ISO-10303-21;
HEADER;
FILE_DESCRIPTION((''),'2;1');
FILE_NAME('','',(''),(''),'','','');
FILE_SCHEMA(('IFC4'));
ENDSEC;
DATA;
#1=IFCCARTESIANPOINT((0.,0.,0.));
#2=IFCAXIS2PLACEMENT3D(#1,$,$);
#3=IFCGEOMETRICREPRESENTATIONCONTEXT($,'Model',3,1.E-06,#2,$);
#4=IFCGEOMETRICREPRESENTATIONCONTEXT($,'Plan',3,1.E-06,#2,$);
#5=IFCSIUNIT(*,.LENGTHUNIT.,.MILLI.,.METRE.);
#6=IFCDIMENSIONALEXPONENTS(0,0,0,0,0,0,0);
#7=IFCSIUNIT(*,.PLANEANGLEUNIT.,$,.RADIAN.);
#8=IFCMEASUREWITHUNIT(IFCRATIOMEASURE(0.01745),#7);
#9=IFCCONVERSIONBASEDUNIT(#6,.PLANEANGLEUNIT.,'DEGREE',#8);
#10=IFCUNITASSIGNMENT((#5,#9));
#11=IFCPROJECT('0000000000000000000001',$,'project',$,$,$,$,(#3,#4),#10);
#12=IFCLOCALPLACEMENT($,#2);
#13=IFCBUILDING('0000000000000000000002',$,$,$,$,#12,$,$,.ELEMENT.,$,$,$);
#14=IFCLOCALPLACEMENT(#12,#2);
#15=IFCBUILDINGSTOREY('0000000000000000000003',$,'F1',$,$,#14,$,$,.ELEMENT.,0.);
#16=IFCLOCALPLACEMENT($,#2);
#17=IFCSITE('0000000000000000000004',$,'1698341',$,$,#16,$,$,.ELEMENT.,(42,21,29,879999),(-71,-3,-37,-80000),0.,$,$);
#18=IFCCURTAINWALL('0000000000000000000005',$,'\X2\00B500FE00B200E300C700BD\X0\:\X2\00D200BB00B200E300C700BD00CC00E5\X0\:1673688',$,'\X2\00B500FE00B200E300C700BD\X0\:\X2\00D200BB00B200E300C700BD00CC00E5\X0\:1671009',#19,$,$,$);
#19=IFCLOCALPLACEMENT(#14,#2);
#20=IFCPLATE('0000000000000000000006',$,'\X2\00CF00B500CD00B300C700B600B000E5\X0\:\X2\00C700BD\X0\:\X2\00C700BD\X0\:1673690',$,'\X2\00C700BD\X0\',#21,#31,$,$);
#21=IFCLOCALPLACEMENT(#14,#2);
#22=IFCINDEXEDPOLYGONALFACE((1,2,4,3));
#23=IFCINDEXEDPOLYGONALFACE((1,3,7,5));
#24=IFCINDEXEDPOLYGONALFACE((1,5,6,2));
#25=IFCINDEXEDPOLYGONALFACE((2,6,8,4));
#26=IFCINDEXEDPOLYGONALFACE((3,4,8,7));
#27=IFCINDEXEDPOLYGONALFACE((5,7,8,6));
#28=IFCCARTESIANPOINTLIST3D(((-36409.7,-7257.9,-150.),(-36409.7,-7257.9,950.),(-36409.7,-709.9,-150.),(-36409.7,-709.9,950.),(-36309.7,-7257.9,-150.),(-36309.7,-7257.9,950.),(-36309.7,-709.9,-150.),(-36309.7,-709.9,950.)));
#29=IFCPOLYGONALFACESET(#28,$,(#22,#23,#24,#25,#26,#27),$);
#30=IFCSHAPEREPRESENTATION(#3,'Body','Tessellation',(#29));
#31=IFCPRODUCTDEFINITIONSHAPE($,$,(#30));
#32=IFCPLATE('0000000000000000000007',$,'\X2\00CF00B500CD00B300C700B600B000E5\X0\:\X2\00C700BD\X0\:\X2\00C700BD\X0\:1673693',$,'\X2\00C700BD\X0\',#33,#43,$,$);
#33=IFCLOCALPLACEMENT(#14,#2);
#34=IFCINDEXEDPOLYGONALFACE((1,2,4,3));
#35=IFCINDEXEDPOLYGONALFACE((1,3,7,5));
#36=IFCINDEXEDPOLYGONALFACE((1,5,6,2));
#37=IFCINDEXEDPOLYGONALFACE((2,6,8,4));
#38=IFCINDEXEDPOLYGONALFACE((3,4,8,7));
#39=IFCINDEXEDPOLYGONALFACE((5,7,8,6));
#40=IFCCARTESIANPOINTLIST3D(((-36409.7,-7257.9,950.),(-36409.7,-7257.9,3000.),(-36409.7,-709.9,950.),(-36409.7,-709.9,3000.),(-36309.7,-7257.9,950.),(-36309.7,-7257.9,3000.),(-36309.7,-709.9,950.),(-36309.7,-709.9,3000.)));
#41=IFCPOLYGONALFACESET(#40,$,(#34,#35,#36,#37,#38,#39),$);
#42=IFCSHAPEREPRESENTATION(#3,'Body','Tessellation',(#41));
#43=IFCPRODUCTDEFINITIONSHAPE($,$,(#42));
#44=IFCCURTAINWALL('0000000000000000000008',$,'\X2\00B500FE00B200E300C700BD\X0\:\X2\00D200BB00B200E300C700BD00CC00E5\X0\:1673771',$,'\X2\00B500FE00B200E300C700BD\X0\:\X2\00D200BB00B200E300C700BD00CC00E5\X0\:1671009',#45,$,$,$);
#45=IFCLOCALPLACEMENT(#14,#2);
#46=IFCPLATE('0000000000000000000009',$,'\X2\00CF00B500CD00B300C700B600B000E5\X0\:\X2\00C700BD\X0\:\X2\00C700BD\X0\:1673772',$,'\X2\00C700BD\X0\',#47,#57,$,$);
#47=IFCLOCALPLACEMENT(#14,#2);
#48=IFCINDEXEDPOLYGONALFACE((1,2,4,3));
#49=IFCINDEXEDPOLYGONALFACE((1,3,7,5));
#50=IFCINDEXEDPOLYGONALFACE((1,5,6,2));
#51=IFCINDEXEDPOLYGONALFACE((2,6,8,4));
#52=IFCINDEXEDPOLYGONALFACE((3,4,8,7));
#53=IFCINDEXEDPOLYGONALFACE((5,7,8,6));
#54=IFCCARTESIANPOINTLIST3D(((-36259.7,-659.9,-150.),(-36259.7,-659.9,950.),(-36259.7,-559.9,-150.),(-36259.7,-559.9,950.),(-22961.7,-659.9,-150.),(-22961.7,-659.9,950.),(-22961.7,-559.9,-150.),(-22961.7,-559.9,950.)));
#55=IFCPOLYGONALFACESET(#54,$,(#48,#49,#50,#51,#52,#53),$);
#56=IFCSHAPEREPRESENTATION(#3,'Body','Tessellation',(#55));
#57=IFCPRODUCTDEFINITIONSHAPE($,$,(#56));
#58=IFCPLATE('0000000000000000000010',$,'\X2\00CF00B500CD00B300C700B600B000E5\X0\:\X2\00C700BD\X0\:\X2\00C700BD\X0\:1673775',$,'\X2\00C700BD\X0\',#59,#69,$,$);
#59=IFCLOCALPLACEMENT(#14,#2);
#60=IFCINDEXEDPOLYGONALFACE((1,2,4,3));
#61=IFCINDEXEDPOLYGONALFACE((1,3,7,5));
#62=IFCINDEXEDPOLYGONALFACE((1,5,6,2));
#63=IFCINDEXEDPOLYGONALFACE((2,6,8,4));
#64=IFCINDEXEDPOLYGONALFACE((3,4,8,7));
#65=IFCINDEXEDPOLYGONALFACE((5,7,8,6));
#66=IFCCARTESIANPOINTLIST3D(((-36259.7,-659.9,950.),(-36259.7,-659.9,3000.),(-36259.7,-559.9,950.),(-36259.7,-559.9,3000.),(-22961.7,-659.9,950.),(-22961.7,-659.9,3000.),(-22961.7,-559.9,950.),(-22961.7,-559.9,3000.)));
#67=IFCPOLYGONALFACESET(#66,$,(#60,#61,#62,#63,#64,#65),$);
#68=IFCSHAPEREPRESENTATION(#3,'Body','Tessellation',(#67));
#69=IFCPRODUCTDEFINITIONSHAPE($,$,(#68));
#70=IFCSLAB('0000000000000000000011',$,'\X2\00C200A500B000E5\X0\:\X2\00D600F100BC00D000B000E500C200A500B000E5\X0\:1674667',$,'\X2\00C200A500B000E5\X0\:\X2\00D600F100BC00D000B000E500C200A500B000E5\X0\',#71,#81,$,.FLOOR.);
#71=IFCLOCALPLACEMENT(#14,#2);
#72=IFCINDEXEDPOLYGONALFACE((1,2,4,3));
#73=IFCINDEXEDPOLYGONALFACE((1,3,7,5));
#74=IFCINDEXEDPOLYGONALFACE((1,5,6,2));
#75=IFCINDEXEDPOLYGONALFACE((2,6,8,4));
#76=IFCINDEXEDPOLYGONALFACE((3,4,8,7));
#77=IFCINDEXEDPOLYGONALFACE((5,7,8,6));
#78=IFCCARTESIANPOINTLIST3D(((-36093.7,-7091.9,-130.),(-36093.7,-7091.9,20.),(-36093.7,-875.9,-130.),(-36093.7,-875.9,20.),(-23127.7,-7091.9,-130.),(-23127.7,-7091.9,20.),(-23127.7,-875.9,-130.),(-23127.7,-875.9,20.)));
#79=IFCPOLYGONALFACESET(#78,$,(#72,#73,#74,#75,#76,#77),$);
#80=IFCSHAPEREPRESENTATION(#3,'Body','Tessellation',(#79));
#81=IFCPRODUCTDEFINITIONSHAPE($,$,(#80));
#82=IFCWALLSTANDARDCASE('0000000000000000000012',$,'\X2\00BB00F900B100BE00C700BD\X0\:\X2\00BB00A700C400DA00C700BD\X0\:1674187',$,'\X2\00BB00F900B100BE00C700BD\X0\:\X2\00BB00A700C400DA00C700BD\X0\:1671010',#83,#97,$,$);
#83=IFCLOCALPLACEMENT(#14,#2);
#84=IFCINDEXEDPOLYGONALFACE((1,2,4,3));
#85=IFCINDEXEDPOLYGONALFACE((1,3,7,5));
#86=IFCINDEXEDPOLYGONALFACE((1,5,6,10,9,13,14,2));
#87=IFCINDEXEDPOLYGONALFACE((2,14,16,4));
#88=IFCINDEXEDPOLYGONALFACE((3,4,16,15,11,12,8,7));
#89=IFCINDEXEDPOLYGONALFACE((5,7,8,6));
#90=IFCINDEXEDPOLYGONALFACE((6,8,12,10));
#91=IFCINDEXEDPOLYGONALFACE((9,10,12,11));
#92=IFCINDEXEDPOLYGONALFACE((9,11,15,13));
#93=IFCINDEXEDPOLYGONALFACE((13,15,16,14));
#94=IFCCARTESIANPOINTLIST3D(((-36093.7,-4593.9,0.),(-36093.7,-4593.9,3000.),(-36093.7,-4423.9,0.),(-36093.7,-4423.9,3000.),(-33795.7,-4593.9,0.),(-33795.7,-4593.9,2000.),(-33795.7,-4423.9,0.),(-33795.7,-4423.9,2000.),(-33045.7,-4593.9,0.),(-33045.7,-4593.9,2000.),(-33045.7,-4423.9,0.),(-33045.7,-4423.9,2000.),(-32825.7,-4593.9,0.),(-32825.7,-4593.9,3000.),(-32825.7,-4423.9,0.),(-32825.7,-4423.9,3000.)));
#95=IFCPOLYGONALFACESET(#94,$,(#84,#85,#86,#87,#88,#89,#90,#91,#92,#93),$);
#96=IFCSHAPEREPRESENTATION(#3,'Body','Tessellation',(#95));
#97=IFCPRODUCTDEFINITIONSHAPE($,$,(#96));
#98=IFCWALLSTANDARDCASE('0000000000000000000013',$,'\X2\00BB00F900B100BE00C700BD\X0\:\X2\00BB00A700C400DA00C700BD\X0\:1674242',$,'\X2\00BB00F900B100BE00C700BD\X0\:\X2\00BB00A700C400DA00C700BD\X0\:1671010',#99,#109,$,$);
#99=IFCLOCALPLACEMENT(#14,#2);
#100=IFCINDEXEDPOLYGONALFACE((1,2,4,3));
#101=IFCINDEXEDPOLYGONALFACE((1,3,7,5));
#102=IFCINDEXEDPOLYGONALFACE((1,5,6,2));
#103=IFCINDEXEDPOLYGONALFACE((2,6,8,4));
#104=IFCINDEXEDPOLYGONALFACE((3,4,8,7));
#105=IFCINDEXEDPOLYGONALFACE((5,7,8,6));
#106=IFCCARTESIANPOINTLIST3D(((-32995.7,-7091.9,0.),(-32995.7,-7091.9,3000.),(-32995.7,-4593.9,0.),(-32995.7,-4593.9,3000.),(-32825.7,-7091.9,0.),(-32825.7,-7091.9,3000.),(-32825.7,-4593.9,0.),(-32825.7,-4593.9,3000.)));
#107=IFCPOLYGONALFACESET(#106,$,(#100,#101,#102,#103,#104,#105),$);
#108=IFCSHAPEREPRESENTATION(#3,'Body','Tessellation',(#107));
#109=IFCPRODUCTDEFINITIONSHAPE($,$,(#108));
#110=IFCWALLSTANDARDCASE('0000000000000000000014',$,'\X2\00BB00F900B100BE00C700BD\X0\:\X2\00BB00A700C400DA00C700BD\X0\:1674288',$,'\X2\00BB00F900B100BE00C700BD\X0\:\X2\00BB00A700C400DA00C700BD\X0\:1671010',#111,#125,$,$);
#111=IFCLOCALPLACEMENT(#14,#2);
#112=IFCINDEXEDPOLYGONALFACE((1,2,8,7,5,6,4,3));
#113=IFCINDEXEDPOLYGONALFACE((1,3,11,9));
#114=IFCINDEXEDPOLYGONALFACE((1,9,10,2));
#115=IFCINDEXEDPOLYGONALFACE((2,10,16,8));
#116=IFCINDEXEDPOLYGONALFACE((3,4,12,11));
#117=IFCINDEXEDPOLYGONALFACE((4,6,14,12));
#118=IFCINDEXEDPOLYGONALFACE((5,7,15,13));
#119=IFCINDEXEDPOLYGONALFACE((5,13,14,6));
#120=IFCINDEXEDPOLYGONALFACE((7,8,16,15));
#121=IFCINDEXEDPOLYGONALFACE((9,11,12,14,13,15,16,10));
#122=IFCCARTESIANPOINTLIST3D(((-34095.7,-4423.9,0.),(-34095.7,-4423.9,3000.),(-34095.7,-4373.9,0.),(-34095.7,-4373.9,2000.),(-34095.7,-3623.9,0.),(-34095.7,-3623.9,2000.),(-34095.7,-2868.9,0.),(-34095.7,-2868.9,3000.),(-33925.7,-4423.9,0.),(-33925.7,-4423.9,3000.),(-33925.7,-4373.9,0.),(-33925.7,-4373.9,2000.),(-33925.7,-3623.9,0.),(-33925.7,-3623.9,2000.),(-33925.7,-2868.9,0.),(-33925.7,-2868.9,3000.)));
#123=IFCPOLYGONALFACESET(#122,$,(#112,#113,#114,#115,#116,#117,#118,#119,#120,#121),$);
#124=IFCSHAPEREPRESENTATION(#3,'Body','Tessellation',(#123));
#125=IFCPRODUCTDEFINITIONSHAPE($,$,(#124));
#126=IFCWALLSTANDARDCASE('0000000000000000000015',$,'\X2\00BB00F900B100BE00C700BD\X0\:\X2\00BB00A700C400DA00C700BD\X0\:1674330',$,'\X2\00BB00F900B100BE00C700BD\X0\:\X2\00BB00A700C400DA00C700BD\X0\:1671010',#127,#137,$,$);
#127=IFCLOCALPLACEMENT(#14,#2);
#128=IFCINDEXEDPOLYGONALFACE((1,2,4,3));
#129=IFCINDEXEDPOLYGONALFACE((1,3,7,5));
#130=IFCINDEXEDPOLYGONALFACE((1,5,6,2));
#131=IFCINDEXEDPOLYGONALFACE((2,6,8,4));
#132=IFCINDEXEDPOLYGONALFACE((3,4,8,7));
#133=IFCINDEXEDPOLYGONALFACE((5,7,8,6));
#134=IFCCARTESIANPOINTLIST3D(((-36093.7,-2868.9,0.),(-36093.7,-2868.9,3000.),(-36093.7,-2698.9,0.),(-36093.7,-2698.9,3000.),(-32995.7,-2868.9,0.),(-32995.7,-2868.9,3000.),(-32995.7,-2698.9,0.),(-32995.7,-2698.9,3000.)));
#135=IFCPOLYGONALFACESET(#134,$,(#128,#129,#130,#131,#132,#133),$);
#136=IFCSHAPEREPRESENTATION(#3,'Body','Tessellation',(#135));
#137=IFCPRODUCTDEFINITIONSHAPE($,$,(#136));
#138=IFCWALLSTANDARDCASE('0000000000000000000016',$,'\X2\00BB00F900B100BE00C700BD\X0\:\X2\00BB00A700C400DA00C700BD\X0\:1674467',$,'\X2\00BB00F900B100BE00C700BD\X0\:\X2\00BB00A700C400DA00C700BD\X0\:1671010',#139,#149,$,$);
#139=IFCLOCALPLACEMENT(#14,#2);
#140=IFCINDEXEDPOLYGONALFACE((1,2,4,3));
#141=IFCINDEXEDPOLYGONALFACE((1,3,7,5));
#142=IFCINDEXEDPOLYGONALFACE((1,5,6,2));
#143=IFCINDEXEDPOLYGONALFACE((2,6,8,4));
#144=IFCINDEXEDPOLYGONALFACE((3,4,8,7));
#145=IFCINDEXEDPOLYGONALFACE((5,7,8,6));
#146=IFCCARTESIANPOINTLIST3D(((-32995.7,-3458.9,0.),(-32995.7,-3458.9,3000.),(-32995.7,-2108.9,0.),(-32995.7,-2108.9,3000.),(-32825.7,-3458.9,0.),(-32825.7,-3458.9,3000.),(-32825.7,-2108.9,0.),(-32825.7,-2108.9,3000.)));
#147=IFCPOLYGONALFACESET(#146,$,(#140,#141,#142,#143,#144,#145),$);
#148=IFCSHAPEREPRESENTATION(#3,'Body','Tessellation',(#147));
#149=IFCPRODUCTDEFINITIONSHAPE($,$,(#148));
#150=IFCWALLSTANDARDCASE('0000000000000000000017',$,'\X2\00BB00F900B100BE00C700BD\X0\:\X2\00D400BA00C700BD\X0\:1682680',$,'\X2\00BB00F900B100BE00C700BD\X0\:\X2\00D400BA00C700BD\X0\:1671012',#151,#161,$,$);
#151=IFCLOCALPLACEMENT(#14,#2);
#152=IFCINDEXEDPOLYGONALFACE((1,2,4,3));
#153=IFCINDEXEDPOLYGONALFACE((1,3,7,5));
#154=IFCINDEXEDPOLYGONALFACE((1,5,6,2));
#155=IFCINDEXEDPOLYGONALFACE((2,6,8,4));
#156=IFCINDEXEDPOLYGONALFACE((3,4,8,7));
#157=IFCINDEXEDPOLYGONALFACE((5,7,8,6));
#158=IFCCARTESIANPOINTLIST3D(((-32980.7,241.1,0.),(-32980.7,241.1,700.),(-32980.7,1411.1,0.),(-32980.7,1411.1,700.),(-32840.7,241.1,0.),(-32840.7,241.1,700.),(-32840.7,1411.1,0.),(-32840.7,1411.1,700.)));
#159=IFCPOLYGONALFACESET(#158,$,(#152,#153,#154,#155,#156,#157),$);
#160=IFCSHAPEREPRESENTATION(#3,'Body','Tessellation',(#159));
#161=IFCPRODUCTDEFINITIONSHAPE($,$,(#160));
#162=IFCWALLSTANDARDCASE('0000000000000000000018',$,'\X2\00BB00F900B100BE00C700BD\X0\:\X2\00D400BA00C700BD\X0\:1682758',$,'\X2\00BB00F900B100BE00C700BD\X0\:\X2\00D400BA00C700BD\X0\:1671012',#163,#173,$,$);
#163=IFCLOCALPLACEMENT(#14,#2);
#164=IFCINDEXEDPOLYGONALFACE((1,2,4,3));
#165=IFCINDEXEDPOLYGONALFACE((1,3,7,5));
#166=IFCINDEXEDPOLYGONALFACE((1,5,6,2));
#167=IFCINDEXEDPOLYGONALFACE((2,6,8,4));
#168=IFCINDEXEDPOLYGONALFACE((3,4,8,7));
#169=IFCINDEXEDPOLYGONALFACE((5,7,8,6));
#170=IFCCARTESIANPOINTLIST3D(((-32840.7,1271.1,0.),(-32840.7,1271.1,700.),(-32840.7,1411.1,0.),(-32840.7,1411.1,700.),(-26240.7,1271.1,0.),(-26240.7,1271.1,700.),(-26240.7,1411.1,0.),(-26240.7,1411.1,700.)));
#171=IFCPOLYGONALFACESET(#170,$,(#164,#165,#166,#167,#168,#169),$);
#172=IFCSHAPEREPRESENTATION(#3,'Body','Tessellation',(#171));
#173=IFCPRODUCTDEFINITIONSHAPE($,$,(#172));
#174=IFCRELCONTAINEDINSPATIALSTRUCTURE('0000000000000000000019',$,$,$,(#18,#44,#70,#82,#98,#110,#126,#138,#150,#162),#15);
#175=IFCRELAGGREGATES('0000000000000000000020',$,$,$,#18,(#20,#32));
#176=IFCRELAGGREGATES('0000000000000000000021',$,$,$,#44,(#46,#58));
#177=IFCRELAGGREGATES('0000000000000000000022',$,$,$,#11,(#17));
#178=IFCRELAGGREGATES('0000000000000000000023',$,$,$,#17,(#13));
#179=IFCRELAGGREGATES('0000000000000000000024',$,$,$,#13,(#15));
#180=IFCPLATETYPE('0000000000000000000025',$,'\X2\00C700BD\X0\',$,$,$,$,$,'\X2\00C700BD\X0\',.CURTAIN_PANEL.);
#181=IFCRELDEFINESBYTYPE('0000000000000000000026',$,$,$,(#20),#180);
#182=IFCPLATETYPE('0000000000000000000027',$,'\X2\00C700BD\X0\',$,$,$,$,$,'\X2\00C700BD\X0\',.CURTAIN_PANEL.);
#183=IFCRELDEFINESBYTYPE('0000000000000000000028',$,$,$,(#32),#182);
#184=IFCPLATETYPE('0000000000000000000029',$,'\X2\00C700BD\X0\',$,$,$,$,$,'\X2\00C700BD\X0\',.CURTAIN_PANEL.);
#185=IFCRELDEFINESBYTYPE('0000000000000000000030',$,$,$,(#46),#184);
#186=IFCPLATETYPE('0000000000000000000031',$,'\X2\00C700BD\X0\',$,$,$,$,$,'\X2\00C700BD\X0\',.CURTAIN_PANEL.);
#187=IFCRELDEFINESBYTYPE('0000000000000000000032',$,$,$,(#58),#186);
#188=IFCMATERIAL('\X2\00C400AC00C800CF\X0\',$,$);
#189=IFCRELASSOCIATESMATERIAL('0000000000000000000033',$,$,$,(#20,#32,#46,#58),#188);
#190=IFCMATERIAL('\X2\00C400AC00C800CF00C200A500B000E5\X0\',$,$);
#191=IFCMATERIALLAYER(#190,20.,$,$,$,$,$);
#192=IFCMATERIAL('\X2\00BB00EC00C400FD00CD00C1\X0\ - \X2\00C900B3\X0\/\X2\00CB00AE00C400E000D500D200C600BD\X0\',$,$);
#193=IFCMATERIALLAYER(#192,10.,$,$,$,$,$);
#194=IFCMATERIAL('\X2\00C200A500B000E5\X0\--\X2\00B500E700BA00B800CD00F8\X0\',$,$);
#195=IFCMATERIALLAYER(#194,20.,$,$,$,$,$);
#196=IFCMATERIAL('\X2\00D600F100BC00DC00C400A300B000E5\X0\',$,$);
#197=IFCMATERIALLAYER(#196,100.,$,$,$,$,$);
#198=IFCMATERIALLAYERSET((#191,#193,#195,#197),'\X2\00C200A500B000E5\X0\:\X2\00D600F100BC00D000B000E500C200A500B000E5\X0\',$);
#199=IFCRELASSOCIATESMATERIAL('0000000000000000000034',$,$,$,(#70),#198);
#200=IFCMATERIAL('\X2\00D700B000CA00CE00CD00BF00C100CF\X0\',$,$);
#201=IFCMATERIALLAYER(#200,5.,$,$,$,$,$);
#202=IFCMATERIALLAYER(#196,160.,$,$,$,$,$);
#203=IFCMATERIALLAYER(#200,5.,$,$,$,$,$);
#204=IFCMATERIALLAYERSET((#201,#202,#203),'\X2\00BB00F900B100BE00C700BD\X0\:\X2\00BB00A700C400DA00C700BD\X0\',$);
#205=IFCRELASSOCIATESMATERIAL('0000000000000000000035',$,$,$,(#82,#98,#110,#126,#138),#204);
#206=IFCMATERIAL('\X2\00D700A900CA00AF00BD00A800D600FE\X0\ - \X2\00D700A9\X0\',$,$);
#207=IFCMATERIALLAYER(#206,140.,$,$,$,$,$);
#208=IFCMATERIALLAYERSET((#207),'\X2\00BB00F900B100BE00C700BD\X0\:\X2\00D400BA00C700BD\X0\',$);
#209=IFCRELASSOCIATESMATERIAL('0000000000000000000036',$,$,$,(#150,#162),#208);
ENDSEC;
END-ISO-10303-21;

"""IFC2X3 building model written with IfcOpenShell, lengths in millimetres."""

from ifc_helpers import new_model, entity, si_unit, converted_unit, frame, frame_2d, origin, origin_2d_with_axis, place, context, project, spatial, rectangle, extrude, source, transform, mapped, material, layer, layer_set, layer_usage, type_object, type_shapes, element, aggregate, save


model = new_model("IFC2X3")

# Units and contexts
model_context = context("Model", 3, precision=1e-06, world=origin())
plan_context = context("Plan", 3, precision=1e-06, world=origin())
ifc_project = project(units=[si_unit("LENGTHUNIT", "METRE", prefix="MILLI"), converted_unit("PLANEANGLEUNIT", "DEGREE", entity("IfcRatioMeasure", 0.01745), si_unit("PLANEANGLEUNIT", "RADIAN"), dimensions=[0, 0, 0, 0, 0, 0, 0])], contexts=[model_context, plan_context])

# Site, building, storey
site_placement = place(None, origin())
site = spatial("IfcSite", under=ifc_project, at=site_placement, Name="1698341", CompositionType="ELEMENT", RefLatitude=(42, 21, 29, 879999), RefLongitude=(-71, -3, -37, -80000), RefElevation=0.0)
building_placement = place(None, origin())
building = spatial("IfcBuilding", under=site, at=building_placement, CompositionType="ELEMENT")
storey_placement = place(building_placement, origin())
storey = spatial("IfcBuildingStorey", under=building, at=storey_placement, Name="F1", CompositionType="ELEMENT", Elevation=0.0)

# Curtain walls, plates
curtain_wall_1_placement = place(storey_placement, origin())
curtain_wall_1 = element("IfcCurtainWall", 1, at=curtain_wall_1_placement, inside=storey, Name="µþ²ãÇ½:Ò»²ãÇ½Ìå:1673688", ObjectType="µþ²ãÇ½:Ò»²ãÇ½Ìå:1671009")
ifc_material_1 = material(Name="Ä¬ÈÏ")
plate_type_1 = type_object("IfcPlateType", Name="Ç½", ElementType="Ç½", PredefinedType="CURTAIN_PANEL")
shared_shape_1 = source(origin(), model_context, "Body", "SweptSolid", [
    extrude(rectangle(XDim=100.0, YDim=6548.0, at=origin_2d_with_axis()), frame((0.0, 100.0, 0.0), z_axis=(0.0, 0.0, 1.0), x_axis=(0.0, 1.0, 0.0)), (0.0, 0.0, 1.0), 1100.0),
])
type_shapes(plate_type_1, [shared_shape_1])
plate_1_placement = place(None, frame((-36259.7, -3983.9, -150.0), z_axis=(0.0, 0.0, 1.0), x_axis=(0.0, 1.0, 0.0)))
plate_1 = element("IfcPlate", 2, at=plate_1_placement, type_object=plate_type_1, material=ifc_material_1, Name="ÏµÍ³Ç¶°å:Ç½:Ç½:1673690", ObjectType="Ç½", context=model_context, shape_type="MappedRepresentation", body=[
    mapped(shared_shape_1, transform((0.0, 0.0, 0.0), scale=1.0)),
])
plate_type_2 = type_object("IfcPlateType", Name="Ç½", ElementType="Ç½", PredefinedType="CURTAIN_PANEL")
shared_shape_2 = source(origin(), model_context, "Body", "SweptSolid", [
    extrude(rectangle(XDim=100.0, YDim=6548.0, at=origin_2d_with_axis()), frame((0.0, 100.0, 0.0), z_axis=(0.0, 0.0, 1.0), x_axis=(0.0, 1.0, 0.0)), (0.0, 0.0, 1.0), 2050.0),
])
type_shapes(plate_type_2, [shared_shape_2])
plate_2_placement = place(None, frame((-36259.7, -3983.9, 950.0), z_axis=(0.0, 0.0, 1.0), x_axis=(0.0, 1.0, 0.0)))
plate_2 = element("IfcPlate", 3, at=plate_2_placement, type_object=plate_type_2, material=ifc_material_1, Name="ÏµÍ³Ç¶°å:Ç½:Ç½:1673693", ObjectType="Ç½", context=model_context, shape_type="MappedRepresentation", body=[
    mapped(shared_shape_2, transform((0.0, 0.0, 0.0), scale=1.0)),
])
aggregate(curtain_wall_1, [plate_1, plate_2])
curtain_wall_2_placement = place(storey_placement, origin())
curtain_wall_2 = element("IfcCurtainWall", 4, at=curtain_wall_2_placement, inside=storey, Name="µþ²ãÇ½:Ò»²ãÇ½Ìå:1673771", ObjectType="µþ²ãÇ½:Ò»²ãÇ½Ìå:1671009")
plate_type_3 = type_object("IfcPlateType", Name="Ç½", ElementType="Ç½", PredefinedType="CURTAIN_PANEL")
shared_shape_3 = source(origin(), model_context, "Body", "SweptSolid", [
    extrude(rectangle(XDim=100.0, YDim=13298.0, at=origin_2d_with_axis()), frame((0.0, 100.0, 0.0), z_axis=(0.0, 0.0, 1.0), x_axis=(0.0, 1.0, 0.0)), (0.0, 0.0, 1.0), 1100.0),
])
type_shapes(plate_type_3, [shared_shape_3])
plate_3_placement = place(None, frame((-29610.7, -709.9, -150.0)))
plate_3 = element("IfcPlate", 5, at=plate_3_placement, type_object=plate_type_3, material=ifc_material_1, Name="ÏµÍ³Ç¶°å:Ç½:Ç½:1673772", ObjectType="Ç½", context=model_context, shape_type="MappedRepresentation", body=[
    mapped(shared_shape_3, transform((0.0, 0.0, 0.0), scale=1.0)),
])
plate_type_4 = type_object("IfcPlateType", Name="Ç½", ElementType="Ç½", PredefinedType="CURTAIN_PANEL")
shared_shape_4 = source(origin(), model_context, "Body", "SweptSolid", [
    extrude(rectangle(XDim=100.0, YDim=13298.0, at=origin_2d_with_axis()), frame((0.0, 100.0, 0.0), z_axis=(0.0, 0.0, 1.0), x_axis=(0.0, 1.0, 0.0)), (0.0, 0.0, 1.0), 2050.0),
])
type_shapes(plate_type_4, [shared_shape_4])
plate_4_placement = place(None, frame((-29610.7, -709.9, 950.0)))
plate_4 = element("IfcPlate", 6, at=plate_4_placement, type_object=plate_type_4, material=ifc_material_1, Name="ÏµÍ³Ç¶°å:Ç½:Ç½:1673775", ObjectType="Ç½", context=model_context, shape_type="MappedRepresentation", body=[
    mapped(shared_shape_4, transform((0.0, 0.0, 0.0), scale=1.0)),
])
aggregate(curtain_wall_2, [plate_3, plate_4])

# Slab
ifc_material_2 = material(Name="Ä¬ÈÏÂ¥°å")
ifc_layer_1 = layer(ifc_material_2, 20.0)
ifc_material_3 = material(Name="»ìÄýÍÁ - É³/Ë®ÄàÕÒÆ½")
ifc_layer_2 = layer(ifc_material_3, 10.0)
ifc_material_4 = material(Name="Â¥°å--µçº¸Íø")
ifc_layer_3 = layer(ifc_material_4, 20.0)
ifc_material_5 = material(Name="Öñ¼ÜÄ£°å")
ifc_layer_4 = layer(ifc_material_5, 100.0)
ifc_layer_set_1 = layer_set([ifc_layer_1, ifc_layer_2, ifc_layer_3, ifc_layer_4], Name="Â¥°å:Öñ¼Ð°åÂ¥°å")
ifc_layer_usage_1 = layer_usage(ifc_layer_set_1, "AXIS3", "POSITIVE", 0.0)
slab_placement = place(storey_placement, frame((-36093.7, -7091.9, -130.0)))
element("IfcSlab", 7, at=slab_placement, inside=storey, material=ifc_layer_usage_1, Name="Â¥°å:Öñ¼Ð°åÂ¥°å:1674667", ObjectType="Â¥°å:Öñ¼Ð°åÂ¥°å", PredefinedType="FLOOR", context=model_context, shape_type="SweptSolid", body=[
    extrude(rectangle(XDim=6216.0, YDim=12966.0, at=frame_2d((0.0, 0.0), x_axis=(0.0, -1.0))), frame((6483.0, 3108.0, 150.0), z_axis=(0.0, 0.0, -1.0), x_axis=(-1.0, 0.0, 0.0)), (0.0, 0.0, 1.0), 150.0),
])

# Shared definitions
ifc_material_6 = material(Name="×°ÊÎÍ¿ÁÏ")

# Wall, opening
ifc_layer_5 = layer(ifc_material_6, 5.0)
ifc_layer_6 = layer(ifc_material_5, 160.0)
ifc_layer_7 = layer(ifc_material_6, 5.0)
ifc_layer_set_2 = layer_set([ifc_layer_5, ifc_layer_6, ifc_layer_7], Name="»ù±¾Ç½:»§ÄÚÇ½")
ifc_layer_usage_2 = layer_usage(ifc_layer_set_2, "AXIS2", "NEGATIVE", 85.0)
wall_1_placement = place(storey_placement, frame((-36093.7, -4508.9, 0.0)))
wall_1 = element("IfcWallStandardCase", 8, at=wall_1_placement, inside=storey, material=ifc_layer_usage_2, Name="»ù±¾Ç½:»§ÄÚÇ½:1674187", ObjectType="»ù±¾Ç½:»§ÄÚÇ½:1671010", context=model_context, shape_type="SweptSolid", body=[
    extrude(rectangle(XDim=3268.0, YDim=170.0, at=frame_2d((1634.0, 0.0), x_axis=(-1.0, 0.0))), origin(), (0.0, 0.0, 1.0), 3000.0),
])
opening_1_placement = place(wall_1_placement, frame((3048.0, 85.0, 0.0)))
element("IfcOpeningElement", 9, at=opening_1_placement, cuts=wall_1, ObjectType="Opening", context=model_context, shape_type="SweptSolid", body=[
    extrude(rectangle(XDim=750.0, YDim=2000.0, at=frame_2d((1000.0, 375.0), x_axis=(0.0, -1.0))), frame((0.0, 0.0, 0.0), z_axis=(0.0, -1.0, 0.0), x_axis=(0.0, 0.0, 1.0)), (0.0, 0.0, 1.0), 170.0),
])

# Wall
ifc_layer_usage_3 = layer_usage(ifc_layer_set_2, "AXIS2", "NEGATIVE", 85.0)
wall_2_placement = place(storey_placement, frame((-32910.7, -4593.9, 0.0), z_axis=(0.0, 0.0, 1.0), x_axis=(0.0, -1.0, 0.0)))
element("IfcWallStandardCase", 10, at=wall_2_placement, inside=storey, material=ifc_layer_usage_3, Name="»ù±¾Ç½:»§ÄÚÇ½:1674242", ObjectType="»ù±¾Ç½:»§ÄÚÇ½:1671010", context=model_context, shape_type="SweptSolid", body=[
    extrude(rectangle(XDim=2498.0, YDim=170.0, at=frame_2d((1249.0, 0.0), x_axis=(-1.0, 0.0))), origin(), (0.0, 0.0, 1.0), 3000.0),
])

# Wall, opening
ifc_layer_usage_4 = layer_usage(ifc_layer_set_2, "AXIS2", "NEGATIVE", 85.0)
wall_3_placement = place(storey_placement, frame((-34010.7, -4423.9, 0.0), z_axis=(0.0, 0.0, 1.0), x_axis=(0.0, 1.0, 0.0)))
wall_3 = element("IfcWallStandardCase", 11, at=wall_3_placement, inside=storey, material=ifc_layer_usage_4, Name="»ù±¾Ç½:»§ÄÚÇ½:1674288", ObjectType="»ù±¾Ç½:»§ÄÚÇ½:1671010", context=model_context, shape_type="SweptSolid", body=[
    extrude(rectangle(XDim=1555.0, YDim=170.0, at=frame_2d((777.5, 0.0), x_axis=(-1.0, 0.0))), origin(), (0.0, 0.0, 1.0), 3000.0),
])
opening_2_placement = place(wall_3_placement, frame((50.0, -85.0, 0.0)))
element("IfcOpeningElement", 12, at=opening_2_placement, cuts=wall_3, ObjectType="Opening", context=model_context, shape_type="SweptSolid", body=[
    extrude(rectangle(XDim=750.0, YDim=2000.0, at=frame_2d((1000.0, 375.0), x_axis=(0.0, -1.0))), frame((0.0, 0.0, 0.0), z_axis=(0.0, 1.0, 0.0), x_axis=(0.0, 0.0, 1.0)), (0.0, 0.0, 1.0), 170.0),
])

# Walls
ifc_layer_usage_5 = layer_usage(ifc_layer_set_2, "AXIS2", "NEGATIVE", 85.0)
wall_4_placement = place(storey_placement, frame((-32995.7, -2783.9, 0.0), z_axis=(0.0, 0.0, 1.0), x_axis=(-1.0, 0.0, 0.0)))
element("IfcWallStandardCase", 13, at=wall_4_placement, inside=storey, material=ifc_layer_usage_5, Name="»ù±¾Ç½:»§ÄÚÇ½:1674330", ObjectType="»ù±¾Ç½:»§ÄÚÇ½:1671010", context=model_context, shape_type="SweptSolid", body=[
    extrude(rectangle(XDim=3098.0, YDim=170.0, at=frame_2d((1549.0, 0.0), x_axis=(-1.0, 0.0))), origin(), (0.0, 0.0, 1.0), 3000.0),
])
ifc_layer_usage_6 = layer_usage(ifc_layer_set_2, "AXIS2", "NEGATIVE", 85.0)
wall_5_placement = place(storey_placement, frame((-32910.7, -3458.9, 0.0), z_axis=(0.0, 0.0, 1.0), x_axis=(0.0, 1.0, 0.0)))
element("IfcWallStandardCase", 14, at=wall_5_placement, inside=storey, material=ifc_layer_usage_6, Name="»ù±¾Ç½:»§ÄÚÇ½:1674467", ObjectType="»ù±¾Ç½:»§ÄÚÇ½:1671010", context=model_context, shape_type="SweptSolid", body=[
    extrude(rectangle(XDim=1350.0, YDim=170.0, at=frame_2d((675.0, 0.0), x_axis=(-1.0, 0.0))), origin(), (0.0, 0.0, 1.0), 3000.0),
])
ifc_material_7 = material(Name="×©Ê¯½¨Öþ - ×©")
ifc_layer_8 = layer(ifc_material_7, 140.0)
ifc_layer_set_3 = layer_set([ifc_layer_8], Name="»ù±¾Ç½:ÔºÇ½")
ifc_layer_usage_7 = layer_usage(ifc_layer_set_3, "AXIS2", "NEGATIVE", 70.0)
wall_6_placement = place(storey_placement, frame((-32910.7, 241.1, 0.0), z_axis=(0.0, 0.0, 1.0), x_axis=(0.0, 1.0, 0.0)))
element("IfcWallStandardCase", 15, at=wall_6_placement, inside=storey, material=ifc_layer_usage_7, Name="»ù±¾Ç½:ÔºÇ½:1682680", ObjectType="»ù±¾Ç½:ÔºÇ½:1671012", context=model_context, shape_type="SweptSolid", body=[
    extrude(rectangle(XDim=1170.0, YDim=140.0, at=frame_2d((585.0, 0.0), x_axis=(-1.0, 0.0))), origin(), (0.0, 0.0, 1.0), 700.0),
])
ifc_layer_usage_8 = layer_usage(ifc_layer_set_3, "AXIS2", "NEGATIVE", 70.0)
wall_7_placement = place(storey_placement, frame((-32840.7, 1341.1, 0.0)))
element("IfcWallStandardCase", 16, at=wall_7_placement, inside=storey, material=ifc_layer_usage_8, Name="»ù±¾Ç½:ÔºÇ½:1682758", ObjectType="»ù±¾Ç½:ÔºÇ½:1671012", context=model_context, shape_type="SweptSolid", body=[
    extrude(rectangle(XDim=6600.0, YDim=140.0, at=frame_2d((3300.0, 0.0), x_axis=(-1.0, 0.0))), origin(), (0.0, 0.0, 1.0), 700.0),
])

save(model, "model.ifc")
